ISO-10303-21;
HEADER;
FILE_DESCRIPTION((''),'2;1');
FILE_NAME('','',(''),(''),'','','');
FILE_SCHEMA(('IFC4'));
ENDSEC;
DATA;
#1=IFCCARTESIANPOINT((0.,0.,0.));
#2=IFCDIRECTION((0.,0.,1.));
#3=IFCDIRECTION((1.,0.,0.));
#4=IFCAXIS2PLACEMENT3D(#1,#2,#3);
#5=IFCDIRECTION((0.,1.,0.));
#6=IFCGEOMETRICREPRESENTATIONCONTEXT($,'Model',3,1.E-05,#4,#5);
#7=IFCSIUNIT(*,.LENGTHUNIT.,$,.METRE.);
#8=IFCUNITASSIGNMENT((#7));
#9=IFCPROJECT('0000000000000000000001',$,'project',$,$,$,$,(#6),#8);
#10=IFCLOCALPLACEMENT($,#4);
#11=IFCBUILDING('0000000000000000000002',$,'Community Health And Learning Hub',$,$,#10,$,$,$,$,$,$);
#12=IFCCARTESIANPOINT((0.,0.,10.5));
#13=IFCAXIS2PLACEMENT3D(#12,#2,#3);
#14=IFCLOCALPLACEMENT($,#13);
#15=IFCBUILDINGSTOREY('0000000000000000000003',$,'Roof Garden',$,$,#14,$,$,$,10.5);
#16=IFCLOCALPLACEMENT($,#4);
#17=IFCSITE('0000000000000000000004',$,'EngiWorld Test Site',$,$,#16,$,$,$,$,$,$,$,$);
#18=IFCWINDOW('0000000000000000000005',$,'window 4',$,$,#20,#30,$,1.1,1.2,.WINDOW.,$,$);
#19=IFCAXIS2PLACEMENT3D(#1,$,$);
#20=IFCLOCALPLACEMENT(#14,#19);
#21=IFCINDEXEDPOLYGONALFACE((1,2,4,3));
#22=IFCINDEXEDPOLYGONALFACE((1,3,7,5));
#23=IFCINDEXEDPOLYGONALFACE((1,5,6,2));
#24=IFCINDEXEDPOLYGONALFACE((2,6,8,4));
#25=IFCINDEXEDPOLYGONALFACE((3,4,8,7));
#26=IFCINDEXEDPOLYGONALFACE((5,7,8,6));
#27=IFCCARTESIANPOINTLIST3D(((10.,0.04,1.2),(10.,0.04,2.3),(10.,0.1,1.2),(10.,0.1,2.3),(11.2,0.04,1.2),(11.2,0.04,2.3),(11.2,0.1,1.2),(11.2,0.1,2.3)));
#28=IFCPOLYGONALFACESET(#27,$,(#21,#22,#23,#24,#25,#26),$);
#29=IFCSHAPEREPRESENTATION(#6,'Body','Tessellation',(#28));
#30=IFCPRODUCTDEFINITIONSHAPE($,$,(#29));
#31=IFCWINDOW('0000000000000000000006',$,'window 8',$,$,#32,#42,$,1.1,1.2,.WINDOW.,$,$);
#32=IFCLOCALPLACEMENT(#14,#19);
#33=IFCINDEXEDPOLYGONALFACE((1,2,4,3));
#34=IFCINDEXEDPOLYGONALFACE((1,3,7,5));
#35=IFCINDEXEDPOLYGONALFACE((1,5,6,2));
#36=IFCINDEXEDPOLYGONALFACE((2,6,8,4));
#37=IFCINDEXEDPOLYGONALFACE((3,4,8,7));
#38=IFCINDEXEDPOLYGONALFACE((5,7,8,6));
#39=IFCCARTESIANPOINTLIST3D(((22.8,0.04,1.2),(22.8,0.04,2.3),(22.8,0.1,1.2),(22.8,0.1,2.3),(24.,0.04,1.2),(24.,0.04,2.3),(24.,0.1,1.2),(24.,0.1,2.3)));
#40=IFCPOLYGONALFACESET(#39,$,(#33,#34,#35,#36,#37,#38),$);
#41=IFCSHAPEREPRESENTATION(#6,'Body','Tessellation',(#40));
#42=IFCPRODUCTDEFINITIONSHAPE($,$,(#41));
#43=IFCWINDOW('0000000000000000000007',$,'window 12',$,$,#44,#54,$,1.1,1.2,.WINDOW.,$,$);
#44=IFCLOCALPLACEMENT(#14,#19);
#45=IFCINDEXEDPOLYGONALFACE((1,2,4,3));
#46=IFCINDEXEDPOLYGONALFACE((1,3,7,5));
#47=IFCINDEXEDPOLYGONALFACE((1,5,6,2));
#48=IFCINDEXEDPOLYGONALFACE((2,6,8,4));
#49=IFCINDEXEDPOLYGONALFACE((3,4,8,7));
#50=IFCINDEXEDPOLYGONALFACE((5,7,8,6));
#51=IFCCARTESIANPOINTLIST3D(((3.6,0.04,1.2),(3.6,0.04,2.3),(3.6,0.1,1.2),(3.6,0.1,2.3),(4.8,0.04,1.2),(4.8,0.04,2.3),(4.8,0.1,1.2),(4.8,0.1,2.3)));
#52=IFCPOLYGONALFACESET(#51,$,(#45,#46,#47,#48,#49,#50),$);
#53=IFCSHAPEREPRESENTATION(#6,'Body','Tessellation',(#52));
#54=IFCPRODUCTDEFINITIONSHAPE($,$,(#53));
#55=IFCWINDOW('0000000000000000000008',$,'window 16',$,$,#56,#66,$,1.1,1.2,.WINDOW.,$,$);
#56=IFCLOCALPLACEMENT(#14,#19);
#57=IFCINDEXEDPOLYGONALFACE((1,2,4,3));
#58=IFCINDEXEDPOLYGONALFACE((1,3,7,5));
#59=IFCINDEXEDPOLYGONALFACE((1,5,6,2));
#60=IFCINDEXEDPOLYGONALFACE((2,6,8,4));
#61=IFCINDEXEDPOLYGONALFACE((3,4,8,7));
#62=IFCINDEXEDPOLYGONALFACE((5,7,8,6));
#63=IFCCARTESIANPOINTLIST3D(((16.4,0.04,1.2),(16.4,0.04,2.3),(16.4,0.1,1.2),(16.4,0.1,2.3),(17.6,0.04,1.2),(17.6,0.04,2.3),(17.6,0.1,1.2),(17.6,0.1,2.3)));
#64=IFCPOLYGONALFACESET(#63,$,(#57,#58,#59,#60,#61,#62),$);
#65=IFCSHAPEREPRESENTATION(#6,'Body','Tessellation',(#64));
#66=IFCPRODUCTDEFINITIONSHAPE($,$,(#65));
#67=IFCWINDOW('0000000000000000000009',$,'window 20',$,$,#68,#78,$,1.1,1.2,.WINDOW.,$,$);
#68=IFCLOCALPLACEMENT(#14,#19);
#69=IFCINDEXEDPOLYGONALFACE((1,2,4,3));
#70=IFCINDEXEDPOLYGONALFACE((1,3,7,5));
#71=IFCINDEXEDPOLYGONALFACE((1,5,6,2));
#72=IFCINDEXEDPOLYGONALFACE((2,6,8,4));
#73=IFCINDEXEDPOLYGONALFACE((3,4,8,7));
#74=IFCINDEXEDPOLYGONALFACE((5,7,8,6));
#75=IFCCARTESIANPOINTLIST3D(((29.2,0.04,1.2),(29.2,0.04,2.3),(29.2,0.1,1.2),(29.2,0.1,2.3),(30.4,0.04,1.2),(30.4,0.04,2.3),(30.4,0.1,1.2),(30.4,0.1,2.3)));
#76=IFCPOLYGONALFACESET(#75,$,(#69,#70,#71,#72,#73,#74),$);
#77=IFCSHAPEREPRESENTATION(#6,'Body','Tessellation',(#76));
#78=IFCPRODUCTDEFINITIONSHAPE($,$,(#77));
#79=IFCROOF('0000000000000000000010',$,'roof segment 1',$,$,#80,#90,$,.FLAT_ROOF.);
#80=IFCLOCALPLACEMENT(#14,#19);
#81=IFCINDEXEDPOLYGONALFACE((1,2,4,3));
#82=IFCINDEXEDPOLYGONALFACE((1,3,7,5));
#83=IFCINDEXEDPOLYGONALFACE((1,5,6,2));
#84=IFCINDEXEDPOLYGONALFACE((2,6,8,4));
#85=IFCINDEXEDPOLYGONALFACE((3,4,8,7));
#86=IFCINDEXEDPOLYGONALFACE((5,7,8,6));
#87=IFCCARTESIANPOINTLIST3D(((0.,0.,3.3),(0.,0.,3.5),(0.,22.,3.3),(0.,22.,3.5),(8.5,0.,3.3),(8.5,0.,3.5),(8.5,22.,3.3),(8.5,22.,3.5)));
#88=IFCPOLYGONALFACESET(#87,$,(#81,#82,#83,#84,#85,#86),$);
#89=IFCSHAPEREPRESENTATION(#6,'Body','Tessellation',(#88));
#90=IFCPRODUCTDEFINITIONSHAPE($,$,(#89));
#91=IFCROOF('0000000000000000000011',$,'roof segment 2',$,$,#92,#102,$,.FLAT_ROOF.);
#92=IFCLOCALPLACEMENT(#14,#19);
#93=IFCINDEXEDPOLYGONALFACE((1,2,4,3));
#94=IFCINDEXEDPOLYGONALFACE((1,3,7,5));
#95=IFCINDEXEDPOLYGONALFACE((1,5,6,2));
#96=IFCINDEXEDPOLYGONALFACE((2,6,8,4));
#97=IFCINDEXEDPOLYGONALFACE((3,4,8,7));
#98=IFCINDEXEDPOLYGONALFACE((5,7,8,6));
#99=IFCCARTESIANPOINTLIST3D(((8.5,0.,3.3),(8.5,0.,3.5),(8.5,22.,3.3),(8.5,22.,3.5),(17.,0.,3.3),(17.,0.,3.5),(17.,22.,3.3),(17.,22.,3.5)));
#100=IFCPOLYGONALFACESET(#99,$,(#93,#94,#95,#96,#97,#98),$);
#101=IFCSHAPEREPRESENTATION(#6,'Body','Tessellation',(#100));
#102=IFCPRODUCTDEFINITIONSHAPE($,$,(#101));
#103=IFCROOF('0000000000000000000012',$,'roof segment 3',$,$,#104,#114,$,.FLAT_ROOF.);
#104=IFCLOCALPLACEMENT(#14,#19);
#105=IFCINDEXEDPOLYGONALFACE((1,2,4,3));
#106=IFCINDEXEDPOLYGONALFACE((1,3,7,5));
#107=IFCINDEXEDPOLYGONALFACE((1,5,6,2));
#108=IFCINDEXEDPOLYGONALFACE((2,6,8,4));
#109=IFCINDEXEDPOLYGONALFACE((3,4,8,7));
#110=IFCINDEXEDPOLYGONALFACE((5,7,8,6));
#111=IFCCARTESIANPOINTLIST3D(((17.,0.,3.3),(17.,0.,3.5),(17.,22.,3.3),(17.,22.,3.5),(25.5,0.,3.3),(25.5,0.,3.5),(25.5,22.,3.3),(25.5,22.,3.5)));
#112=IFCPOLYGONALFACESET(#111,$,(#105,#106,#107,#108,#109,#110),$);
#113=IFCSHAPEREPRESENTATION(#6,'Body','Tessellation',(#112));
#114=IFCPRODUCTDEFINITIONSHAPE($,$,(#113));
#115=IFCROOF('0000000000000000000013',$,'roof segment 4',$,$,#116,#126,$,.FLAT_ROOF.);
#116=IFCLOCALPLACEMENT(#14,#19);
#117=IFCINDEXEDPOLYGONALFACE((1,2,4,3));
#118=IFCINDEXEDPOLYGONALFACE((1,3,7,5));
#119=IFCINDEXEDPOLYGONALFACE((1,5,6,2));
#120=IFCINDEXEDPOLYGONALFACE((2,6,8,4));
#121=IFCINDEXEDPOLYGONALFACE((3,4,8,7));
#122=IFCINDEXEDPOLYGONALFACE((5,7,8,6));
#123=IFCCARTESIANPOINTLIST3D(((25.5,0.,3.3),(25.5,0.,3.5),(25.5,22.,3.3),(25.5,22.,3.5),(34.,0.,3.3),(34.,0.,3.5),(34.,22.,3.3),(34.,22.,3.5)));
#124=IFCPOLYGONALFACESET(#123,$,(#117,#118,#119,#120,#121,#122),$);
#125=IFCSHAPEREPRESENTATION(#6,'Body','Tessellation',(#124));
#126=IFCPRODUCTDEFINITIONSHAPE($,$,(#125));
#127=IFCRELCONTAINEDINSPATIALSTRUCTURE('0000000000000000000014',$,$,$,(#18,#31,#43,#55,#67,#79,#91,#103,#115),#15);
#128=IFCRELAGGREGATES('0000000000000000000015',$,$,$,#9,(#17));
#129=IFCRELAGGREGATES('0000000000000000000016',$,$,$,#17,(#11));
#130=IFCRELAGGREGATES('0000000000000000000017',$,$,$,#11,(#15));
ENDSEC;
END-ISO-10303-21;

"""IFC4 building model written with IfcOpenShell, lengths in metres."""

from ifc_helpers import new_model, si_unit, direction, frame, origin_with_axes, origin_2d_with_axis, place, context, project, spatial, rectangle, extrude, element, save


model = new_model("IFC4")

# Units and contexts
model_context = context("Model", 3, precision=1e-05, world=origin_with_axes(), true_north=direction((0.0, 1.0, 0.0)))
ifc_project = project(units=[si_unit("LENGTHUNIT", "METRE")], contexts=[model_context])

# Site, building, storey
site_placement = place(None, origin_with_axes())
site = spatial("IfcSite", under=ifc_project, at=site_placement, Name="EngiWorld Test Site")
building_placement = place(None, origin_with_axes())
building = spatial("IfcBuilding", under=site, at=building_placement, Name="Community Health And Learning Hub")
storey_placement = place(None, frame((0.0, 0.0, 10.5), z_axis=(0.0, 0.0, 1.0), x_axis=(1.0, 0.0, 0.0)))
storey = spatial("IfcBuildingStorey", under=building, at=storey_placement, Name="Roof Garden", Elevation=10.5)

# Windows
for number, where, z_axis, x_axis, name in (
    (1, (10.6, 0.07, 11.7), (0.0, 0.0, 1.0), (1.0, 0.0, 0.0), "window 4"),
    (2, (23.4, 0.07, 11.7), (0.0, 0.0, 1.0), (1.0, 0.0, 0.0), "window 8"),
    (3, (4.2, 0.07, 11.7), (0.0, 0.0, 1.0), (1.0, 0.0, 0.0), "window 12"),
    (4, (17.0, 0.07, 11.7), (0.0, 0.0, 1.0), (1.0, 0.0, 0.0), "window 16"),
    (5, (29.8, 0.07, 11.7), (0.0, 0.0, 1.0), (1.0, 0.0, 0.0), "window 20"),
):
    element("IfcWindow", number, at=place(None, frame(where, z_axis=z_axis, x_axis=x_axis)), inside=storey, Name=name, OverallHeight=1.1, OverallWidth=1.2, PredefinedType="WINDOW", context=model_context, shape_type="SweptSolid", body=[
        extrude(rectangle(XDim=1.2, YDim=0.06, at=origin_2d_with_axis()), origin_with_axes(), (0.0, 0.0, 1.0), 1.1),
    ])

# Roofs
for number, where, z_axis, x_axis, name in (
    (6, (4.25, 11.0, 13.8), (0.0, 0.0, 1.0), (1.0, 0.0, 0.0), "roof segment 1"),
    (7, (12.75, 11.0, 13.8), (0.0, 0.0, 1.0), (1.0, 0.0, 0.0), "roof segment 2"),
    (8, (21.25, 11.0, 13.8), (0.0, 0.0, 1.0), (1.0, 0.0, 0.0), "roof segment 3"),
    (9, (29.75, 11.0, 13.8), (0.0, 0.0, 1.0), (1.0, 0.0, 0.0), "roof segment 4"),
):
    element("IfcRoof", number, at=place(None, frame(where, z_axis=z_axis, x_axis=x_axis)), inside=storey, Name=name, PredefinedType="FLAT_ROOF", context=model_context, shape_type="SweptSolid", body=[
        extrude(rectangle(XDim=8.5, YDim=22.0, at=origin_2d_with_axis()), origin_with_axes(), (0.0, 0.0, 1.0), 0.2),
    ])

save(model, "model.ifc")
